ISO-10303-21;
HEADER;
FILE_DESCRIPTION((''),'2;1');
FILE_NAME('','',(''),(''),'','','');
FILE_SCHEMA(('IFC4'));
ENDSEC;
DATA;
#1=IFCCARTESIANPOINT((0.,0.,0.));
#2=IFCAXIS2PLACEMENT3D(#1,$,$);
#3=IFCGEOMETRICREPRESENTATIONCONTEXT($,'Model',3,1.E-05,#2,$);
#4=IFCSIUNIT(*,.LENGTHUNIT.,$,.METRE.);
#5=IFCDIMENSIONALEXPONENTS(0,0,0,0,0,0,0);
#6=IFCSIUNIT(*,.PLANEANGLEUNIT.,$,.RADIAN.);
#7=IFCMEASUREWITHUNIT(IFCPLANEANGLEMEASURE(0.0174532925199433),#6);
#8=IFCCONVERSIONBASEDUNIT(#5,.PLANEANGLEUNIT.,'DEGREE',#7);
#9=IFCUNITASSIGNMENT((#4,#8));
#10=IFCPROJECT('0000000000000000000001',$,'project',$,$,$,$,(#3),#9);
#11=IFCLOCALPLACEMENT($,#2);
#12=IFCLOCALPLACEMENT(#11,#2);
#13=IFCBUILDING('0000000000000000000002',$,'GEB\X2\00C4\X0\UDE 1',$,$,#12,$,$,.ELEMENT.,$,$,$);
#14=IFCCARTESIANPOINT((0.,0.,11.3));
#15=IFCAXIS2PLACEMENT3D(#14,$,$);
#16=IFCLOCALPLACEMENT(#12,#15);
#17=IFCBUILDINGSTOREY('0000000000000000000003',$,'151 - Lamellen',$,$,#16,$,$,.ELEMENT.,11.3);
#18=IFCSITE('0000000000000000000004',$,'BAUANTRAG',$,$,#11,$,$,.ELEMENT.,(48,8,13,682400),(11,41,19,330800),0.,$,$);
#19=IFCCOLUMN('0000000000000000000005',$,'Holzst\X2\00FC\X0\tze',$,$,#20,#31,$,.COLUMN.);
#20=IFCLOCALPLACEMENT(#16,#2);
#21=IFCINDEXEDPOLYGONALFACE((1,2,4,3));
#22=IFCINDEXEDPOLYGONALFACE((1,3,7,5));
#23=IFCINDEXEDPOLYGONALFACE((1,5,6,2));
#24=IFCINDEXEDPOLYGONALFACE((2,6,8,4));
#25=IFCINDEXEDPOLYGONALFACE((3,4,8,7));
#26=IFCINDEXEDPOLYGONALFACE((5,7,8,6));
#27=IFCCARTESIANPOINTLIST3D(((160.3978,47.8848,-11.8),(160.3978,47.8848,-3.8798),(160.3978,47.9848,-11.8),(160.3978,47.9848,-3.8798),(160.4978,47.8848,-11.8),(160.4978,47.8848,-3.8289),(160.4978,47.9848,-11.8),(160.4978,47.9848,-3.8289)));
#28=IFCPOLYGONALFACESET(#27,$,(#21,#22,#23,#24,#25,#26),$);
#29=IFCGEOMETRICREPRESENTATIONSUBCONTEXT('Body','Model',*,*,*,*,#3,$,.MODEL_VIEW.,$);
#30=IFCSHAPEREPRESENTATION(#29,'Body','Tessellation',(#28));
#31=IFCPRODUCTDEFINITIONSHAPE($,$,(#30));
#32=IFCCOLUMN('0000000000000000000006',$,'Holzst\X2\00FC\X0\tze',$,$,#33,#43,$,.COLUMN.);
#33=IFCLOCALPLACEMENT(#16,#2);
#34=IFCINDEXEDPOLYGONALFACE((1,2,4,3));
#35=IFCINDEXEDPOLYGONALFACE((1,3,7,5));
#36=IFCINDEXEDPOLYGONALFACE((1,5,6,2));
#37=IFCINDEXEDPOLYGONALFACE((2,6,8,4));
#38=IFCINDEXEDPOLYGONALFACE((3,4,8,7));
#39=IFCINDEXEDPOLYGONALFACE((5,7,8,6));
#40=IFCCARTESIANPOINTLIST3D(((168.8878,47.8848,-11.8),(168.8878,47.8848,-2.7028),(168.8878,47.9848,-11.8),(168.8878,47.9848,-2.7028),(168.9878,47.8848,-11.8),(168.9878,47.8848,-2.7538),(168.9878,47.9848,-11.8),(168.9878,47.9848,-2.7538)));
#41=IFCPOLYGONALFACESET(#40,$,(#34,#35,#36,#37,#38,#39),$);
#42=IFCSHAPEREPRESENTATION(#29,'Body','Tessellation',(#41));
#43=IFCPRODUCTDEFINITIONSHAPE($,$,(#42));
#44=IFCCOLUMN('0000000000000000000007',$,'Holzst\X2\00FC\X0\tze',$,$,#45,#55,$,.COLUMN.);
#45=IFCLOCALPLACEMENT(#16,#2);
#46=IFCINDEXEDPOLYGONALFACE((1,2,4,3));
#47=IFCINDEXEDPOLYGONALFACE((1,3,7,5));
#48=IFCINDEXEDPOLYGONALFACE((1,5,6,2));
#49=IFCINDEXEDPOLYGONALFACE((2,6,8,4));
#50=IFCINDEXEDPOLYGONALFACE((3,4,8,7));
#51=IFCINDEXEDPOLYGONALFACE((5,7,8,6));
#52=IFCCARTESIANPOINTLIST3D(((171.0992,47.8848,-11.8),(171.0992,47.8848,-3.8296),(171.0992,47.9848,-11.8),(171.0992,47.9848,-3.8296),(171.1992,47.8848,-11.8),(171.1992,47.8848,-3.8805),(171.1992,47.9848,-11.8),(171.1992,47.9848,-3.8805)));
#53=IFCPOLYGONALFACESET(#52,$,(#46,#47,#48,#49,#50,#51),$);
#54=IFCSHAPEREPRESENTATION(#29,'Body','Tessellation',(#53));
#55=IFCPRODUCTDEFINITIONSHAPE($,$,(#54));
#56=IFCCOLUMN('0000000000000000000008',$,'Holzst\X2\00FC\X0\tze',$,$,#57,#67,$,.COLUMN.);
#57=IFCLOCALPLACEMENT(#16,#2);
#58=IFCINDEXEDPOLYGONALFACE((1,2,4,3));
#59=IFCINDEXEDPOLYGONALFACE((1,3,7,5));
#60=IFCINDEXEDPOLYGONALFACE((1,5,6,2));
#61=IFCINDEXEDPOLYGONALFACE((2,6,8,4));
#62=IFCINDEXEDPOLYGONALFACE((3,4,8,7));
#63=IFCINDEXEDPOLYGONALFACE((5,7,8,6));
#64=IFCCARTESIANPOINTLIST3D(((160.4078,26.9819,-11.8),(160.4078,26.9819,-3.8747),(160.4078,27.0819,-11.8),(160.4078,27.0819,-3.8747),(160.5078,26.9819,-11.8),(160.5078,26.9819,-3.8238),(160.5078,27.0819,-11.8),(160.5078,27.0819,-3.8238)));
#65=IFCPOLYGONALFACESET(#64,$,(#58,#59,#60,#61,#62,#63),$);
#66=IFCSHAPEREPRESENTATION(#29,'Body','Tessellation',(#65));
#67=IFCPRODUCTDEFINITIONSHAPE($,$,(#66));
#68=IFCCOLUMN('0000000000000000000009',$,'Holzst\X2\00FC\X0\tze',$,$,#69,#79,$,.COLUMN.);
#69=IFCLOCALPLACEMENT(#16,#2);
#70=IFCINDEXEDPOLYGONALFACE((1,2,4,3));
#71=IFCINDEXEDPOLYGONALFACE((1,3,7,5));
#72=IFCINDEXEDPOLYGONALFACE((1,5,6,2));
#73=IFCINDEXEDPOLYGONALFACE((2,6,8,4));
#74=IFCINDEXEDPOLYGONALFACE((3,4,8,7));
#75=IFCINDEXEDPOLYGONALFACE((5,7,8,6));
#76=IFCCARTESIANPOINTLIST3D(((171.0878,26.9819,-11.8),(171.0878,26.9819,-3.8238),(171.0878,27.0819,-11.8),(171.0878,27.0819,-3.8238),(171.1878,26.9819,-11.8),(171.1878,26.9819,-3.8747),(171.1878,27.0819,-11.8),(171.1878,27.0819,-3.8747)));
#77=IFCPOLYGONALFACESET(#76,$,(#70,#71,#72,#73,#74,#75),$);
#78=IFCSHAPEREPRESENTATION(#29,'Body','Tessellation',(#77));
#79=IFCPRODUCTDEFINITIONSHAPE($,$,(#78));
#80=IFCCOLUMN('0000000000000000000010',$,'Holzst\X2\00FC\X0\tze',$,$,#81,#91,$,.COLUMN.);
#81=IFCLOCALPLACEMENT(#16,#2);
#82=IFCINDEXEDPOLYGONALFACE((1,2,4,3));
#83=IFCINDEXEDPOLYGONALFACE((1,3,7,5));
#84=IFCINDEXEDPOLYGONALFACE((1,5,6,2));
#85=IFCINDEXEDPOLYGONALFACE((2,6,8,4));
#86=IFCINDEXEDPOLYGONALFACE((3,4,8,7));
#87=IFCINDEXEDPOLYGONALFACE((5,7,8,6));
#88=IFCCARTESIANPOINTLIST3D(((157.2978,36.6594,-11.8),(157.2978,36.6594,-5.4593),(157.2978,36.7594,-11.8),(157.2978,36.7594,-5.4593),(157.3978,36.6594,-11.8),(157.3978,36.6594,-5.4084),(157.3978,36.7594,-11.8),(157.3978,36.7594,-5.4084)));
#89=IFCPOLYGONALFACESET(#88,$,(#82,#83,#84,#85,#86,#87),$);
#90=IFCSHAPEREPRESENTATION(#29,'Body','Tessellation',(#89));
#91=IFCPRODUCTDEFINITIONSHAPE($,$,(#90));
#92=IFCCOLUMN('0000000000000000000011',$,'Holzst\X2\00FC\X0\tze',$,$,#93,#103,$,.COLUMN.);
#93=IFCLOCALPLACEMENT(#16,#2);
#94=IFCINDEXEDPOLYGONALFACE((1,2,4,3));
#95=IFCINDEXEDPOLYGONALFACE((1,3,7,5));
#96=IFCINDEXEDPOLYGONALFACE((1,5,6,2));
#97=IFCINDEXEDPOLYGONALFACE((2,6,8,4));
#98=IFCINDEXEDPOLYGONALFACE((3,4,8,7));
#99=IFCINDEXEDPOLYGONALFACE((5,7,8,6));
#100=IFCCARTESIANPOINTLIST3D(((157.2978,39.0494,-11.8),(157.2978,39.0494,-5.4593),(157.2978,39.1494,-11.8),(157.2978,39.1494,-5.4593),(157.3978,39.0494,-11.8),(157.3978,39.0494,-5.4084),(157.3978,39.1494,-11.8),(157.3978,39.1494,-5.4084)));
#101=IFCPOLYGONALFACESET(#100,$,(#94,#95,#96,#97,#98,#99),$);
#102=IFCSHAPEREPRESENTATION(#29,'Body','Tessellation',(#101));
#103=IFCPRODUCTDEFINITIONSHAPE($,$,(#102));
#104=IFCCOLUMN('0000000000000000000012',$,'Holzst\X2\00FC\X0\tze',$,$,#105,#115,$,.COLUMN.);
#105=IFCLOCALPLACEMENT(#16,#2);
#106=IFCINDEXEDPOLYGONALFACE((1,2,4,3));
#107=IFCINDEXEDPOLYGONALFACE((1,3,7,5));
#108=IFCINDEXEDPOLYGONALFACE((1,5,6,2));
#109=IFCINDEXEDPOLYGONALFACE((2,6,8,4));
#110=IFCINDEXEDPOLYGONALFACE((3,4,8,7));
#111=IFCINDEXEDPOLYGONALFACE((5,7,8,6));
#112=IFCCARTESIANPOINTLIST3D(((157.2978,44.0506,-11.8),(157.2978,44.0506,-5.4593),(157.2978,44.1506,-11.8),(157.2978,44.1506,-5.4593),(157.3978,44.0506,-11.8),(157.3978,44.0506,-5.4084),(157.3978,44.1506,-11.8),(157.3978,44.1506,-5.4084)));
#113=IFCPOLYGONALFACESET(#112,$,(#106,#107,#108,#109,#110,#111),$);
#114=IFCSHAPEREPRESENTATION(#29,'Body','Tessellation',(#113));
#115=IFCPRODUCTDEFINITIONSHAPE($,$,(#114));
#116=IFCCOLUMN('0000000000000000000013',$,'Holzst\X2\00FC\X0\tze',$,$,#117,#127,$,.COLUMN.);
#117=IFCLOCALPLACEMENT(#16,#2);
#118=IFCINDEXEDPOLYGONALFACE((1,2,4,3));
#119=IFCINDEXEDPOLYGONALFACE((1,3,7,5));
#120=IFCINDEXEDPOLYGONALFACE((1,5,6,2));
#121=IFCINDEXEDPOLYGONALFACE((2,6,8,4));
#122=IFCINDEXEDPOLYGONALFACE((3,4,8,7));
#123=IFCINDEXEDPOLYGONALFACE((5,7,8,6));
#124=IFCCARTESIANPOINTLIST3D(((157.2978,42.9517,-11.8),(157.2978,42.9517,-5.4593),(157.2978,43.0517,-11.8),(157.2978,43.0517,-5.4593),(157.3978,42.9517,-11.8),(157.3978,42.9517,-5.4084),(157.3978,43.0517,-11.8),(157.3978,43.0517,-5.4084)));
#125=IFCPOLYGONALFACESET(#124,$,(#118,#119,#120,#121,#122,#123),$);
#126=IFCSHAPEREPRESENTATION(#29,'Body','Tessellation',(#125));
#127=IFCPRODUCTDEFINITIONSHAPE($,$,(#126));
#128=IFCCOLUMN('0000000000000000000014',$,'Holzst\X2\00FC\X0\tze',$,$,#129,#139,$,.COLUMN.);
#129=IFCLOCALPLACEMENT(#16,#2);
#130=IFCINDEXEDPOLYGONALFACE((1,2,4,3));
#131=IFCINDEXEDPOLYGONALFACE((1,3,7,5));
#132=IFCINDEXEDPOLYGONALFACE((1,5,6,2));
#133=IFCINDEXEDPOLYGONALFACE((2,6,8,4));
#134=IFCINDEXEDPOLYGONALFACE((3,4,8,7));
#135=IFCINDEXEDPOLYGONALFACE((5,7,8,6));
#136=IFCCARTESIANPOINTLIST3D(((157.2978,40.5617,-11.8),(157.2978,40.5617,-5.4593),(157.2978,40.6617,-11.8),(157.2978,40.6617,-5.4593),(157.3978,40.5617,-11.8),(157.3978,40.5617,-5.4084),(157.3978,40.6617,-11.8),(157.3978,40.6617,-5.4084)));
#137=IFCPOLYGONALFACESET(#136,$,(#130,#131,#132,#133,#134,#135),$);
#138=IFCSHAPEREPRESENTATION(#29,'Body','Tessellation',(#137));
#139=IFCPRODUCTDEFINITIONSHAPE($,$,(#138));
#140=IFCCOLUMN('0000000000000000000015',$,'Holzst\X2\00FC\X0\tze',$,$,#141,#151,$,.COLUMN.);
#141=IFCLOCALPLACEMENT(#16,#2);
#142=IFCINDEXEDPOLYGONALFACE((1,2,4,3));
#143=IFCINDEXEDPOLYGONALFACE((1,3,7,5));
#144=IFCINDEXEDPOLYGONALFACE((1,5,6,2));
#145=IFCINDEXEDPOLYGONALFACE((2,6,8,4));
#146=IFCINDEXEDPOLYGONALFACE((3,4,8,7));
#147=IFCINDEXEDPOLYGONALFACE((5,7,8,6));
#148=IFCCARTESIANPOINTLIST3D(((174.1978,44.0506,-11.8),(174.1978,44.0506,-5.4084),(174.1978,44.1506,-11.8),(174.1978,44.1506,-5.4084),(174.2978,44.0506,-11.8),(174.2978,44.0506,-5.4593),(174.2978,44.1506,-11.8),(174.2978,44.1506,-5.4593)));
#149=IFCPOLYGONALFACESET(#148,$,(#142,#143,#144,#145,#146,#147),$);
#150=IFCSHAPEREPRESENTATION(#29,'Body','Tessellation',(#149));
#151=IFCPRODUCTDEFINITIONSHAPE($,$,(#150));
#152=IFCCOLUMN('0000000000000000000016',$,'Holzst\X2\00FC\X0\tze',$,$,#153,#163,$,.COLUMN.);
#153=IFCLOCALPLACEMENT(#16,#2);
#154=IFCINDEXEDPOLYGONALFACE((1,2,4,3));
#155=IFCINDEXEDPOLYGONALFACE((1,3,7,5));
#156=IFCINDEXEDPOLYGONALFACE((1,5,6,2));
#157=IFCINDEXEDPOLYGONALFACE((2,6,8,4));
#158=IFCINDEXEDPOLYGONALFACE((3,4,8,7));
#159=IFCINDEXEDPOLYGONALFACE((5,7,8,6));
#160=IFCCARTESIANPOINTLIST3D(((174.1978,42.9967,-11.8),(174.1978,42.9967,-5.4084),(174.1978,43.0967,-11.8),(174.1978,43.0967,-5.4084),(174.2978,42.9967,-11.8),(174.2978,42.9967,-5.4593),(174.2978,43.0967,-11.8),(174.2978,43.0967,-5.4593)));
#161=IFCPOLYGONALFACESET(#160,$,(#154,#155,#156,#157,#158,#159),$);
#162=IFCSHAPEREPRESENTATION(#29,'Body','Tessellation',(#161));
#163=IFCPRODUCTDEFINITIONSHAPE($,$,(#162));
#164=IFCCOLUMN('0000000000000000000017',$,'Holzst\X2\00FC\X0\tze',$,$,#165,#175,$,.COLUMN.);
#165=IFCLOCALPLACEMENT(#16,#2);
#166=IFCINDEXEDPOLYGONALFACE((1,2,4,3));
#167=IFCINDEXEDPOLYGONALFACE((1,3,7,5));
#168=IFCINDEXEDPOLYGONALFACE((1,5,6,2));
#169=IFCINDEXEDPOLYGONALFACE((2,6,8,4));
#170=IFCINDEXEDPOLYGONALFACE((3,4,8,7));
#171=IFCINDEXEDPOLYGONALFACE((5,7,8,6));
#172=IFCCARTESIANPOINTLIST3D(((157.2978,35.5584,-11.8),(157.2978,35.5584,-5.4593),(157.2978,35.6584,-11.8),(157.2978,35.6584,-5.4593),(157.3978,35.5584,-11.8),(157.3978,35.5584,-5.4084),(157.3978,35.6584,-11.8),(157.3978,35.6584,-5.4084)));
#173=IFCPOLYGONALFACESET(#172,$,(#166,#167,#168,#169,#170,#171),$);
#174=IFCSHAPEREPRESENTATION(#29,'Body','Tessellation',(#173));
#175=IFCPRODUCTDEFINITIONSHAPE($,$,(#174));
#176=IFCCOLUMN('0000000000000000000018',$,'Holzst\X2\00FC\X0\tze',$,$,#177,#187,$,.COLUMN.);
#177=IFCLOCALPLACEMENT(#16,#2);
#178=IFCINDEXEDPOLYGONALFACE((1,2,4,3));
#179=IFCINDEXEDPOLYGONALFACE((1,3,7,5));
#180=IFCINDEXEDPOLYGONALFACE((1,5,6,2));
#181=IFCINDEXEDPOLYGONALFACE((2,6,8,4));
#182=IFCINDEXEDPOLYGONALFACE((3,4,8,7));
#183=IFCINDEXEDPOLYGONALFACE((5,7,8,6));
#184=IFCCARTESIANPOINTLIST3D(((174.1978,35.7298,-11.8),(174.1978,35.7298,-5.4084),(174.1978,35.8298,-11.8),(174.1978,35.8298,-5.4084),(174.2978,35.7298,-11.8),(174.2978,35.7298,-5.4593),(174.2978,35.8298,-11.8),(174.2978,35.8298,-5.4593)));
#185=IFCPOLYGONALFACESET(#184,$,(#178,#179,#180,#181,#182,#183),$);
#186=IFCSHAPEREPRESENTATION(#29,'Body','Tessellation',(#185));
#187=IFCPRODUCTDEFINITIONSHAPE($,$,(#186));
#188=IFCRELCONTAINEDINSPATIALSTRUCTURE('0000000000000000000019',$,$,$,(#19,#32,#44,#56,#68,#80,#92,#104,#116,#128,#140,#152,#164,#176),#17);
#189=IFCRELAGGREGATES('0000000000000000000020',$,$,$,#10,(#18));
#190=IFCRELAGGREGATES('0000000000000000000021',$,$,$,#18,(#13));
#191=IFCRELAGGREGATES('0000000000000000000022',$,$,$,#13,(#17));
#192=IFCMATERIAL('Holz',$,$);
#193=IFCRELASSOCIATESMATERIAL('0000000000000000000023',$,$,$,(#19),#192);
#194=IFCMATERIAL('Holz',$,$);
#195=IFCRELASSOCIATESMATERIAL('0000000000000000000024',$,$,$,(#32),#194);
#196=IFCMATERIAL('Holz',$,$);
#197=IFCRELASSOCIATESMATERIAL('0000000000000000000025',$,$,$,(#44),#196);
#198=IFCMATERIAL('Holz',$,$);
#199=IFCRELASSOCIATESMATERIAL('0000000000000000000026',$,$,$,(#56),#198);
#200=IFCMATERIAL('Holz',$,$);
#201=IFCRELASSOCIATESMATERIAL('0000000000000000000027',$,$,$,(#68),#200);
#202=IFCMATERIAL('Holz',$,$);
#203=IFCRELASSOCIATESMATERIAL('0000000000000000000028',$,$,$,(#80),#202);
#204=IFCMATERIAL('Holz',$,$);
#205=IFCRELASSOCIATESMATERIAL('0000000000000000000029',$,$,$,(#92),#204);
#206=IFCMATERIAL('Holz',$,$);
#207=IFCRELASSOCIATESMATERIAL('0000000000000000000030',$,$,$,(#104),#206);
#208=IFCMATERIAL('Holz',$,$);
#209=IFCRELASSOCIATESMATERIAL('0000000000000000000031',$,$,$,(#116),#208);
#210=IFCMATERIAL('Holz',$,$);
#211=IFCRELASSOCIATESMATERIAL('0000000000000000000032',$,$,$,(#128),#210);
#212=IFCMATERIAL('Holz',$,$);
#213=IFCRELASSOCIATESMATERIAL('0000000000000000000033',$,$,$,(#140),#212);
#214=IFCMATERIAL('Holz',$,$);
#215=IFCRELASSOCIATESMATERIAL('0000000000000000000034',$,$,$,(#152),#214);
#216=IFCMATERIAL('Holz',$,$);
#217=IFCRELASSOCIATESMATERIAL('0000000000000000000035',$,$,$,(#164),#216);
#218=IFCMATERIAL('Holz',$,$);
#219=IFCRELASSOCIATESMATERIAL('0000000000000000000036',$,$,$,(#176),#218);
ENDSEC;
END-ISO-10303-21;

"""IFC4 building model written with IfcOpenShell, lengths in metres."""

from ifc_helpers import new_model, entity, si_unit, converted_unit, frame, frame_2d, origin, origin_with_axes, place, context, subcontext, project, spatial, rectangle, extrude, clip, halfspace, material, element, save


model = new_model("IFC4")

# Units and contexts
model_context = context("Model", 3, precision=1e-05, world=origin())
body_context = subcontext(model_context, "Body", "Model", "MODEL_VIEW")
ifc_project = project(units=[si_unit("LENGTHUNIT", "METRE"), converted_unit("PLANEANGLEUNIT", "DEGREE", entity("IfcPlaneAngleMeasure", 0.0174532925199433), si_unit("PLANEANGLEUNIT", "RADIAN"), dimensions=[0, 0, 0, 0, 0, 0, 0])], contexts=[model_context])

# Site, building, storey
site_placement = place(None, origin())
site = spatial("IfcSite", under=ifc_project, at=site_placement, Name="BAUANTRAG", CompositionType="ELEMENT", RefLatitude=(48, 8, 13, 682400), RefLongitude=(11, 41, 19, 330800), RefElevation=0.0)
building_placement = place(site_placement, origin())
building = spatial("IfcBuilding", under=site, at=building_placement, Name="GEBÄUDE 1", CompositionType="ELEMENT")
storey_placement = place(building_placement, frame((0.0, 0.0, 11.3)))
storey = spatial("IfcBuildingStorey", under=building, at=storey_placement, Name="151 - Lamellen", CompositionType="ELEMENT", Elevation=11.3)

# Columns
ifc_material_1 = material(Name="Holz")
column_1_placement = place(storey_placement, frame((160.4978, 47.8848, -11.8)))
element("IfcColumn", 1, at=column_1_placement, inside=storey, material=ifc_material_1, Name="Holzstütze", PredefinedType="COLUMN", context=body_context, shape_type="Clipping", body=[
    clip(extrude(rectangle(XDim=0.1, YDim=0.1, at=frame_2d((-0.05, 0.05), x_axis=(0.0, 1.0))), origin_with_axes(), (0.0, 0.0, 1.0), 7.9711), halfspace(frame((-0.05, 0.05, 7.9457), z_axis=(0.45399, 0.0, -0.891007), x_axis=(0.0, 1.0, 0.0)), True)),
])
ifc_material_2 = material(Name="Holz")
column_2_placement = place(storey_placement, frame((168.9878, 47.8848, -11.8)))
element("IfcColumn", 2, at=column_2_placement, inside=storey, material=ifc_material_2, Name="Holzstütze", PredefinedType="COLUMN", context=body_context, shape_type="Clipping", body=[
    clip(extrude(rectangle(XDim=0.1, YDim=0.1, at=frame_2d((-0.05, 0.05), x_axis=(0.0, 1.0))), origin_with_axes(), (0.0, 0.0, 1.0), 9.0972), halfspace(frame((-0.05, 0.05, 9.0717), z_axis=(-0.45399, 0.0, -0.891007), x_axis=(0.0, 1.0, 0.0)), True)),
])
ifc_material_3 = material(Name="Holz")
column_3_placement = place(storey_placement, frame((171.1992, 47.8848, -11.8)))
element("IfcColumn", 3, at=column_3_placement, inside=storey, material=ifc_material_3, Name="Holzstütze", PredefinedType="COLUMN", context=body_context, shape_type="Clipping", body=[
    clip(extrude(rectangle(XDim=0.1, YDim=0.1, at=frame_2d((-0.05, 0.05), x_axis=(0.0, 1.0))), origin_with_axes(), (0.0, 0.0, 1.0), 7.9704), halfspace(frame((-0.05, 0.05, 7.9449), z_axis=(-0.45399, 0.0, -0.891007), x_axis=(0.0, 1.0, 0.0)), True)),
])
ifc_material_4 = material(Name="Holz")
column_4_placement = place(storey_placement, frame((160.5078, 26.9819, -11.8)))
element("IfcColumn", 4, at=column_4_placement, inside=storey, material=ifc_material_4, Name="Holzstütze", PredefinedType="COLUMN", context=body_context, shape_type="Clipping", body=[
    clip(extrude(rectangle(XDim=0.1, YDim=0.1, at=frame_2d((-0.05, 0.05), x_axis=(0.0, 1.0))), origin_with_axes(), (0.0, 0.0, 1.0), 7.9762), halfspace(frame((-0.05, 0.05, 7.9508), z_axis=(0.45399, 0.0, -0.891007), x_axis=(0.0, -1.0, 0.0)), True)),
])
ifc_material_5 = material(Name="Holz")
column_5_placement = place(storey_placement, frame((171.1878, 26.9819, -11.8)))
element("IfcColumn", 5, at=column_5_placement, inside=storey, material=ifc_material_5, Name="Holzstütze", PredefinedType="COLUMN", context=body_context, shape_type="Clipping", body=[
    clip(extrude(rectangle(XDim=0.1, YDim=0.1, at=frame_2d((-0.05, 0.05), x_axis=(0.0, 1.0))), origin_with_axes(), (0.0, 0.0, 1.0), 7.9762), halfspace(frame((-0.05, 0.05, 7.9508), z_axis=(-0.45399, 0.0, -0.891007), x_axis=(0.0, -1.0, 0.0)), True)),
])
ifc_material_6 = material(Name="Holz")
column_6_placement = place(storey_placement, frame((157.3978, 36.6594, -11.8)))
element("IfcColumn", 6, at=column_6_placement, inside=storey, material=ifc_material_6, Name="Holzstütze", PredefinedType="COLUMN", context=body_context, shape_type="Clipping", body=[
    clip(extrude(rectangle(XDim=0.1, YDim=0.1, at=frame_2d((-0.05, 0.05), x_axis=(0.0, 1.0))), origin_with_axes(), (0.0, 0.0, 1.0), 6.3916), halfspace(frame((-0.05, 0.05, 6.3661), z_axis=(0.45399, 0.0, -0.891007), x_axis=(-0.891007, 0.0, -0.45399)), True)),
])
ifc_material_7 = material(Name="Holz")
column_7_placement = place(storey_placement, frame((157.3978, 39.0494, -11.8)))
element("IfcColumn", 7, at=column_7_placement, inside=storey, material=ifc_material_7, Name="Holzstütze", PredefinedType="COLUMN", context=body_context, shape_type="Clipping", body=[
    clip(extrude(rectangle(XDim=0.1, YDim=0.1, at=frame_2d((-0.05, 0.05), x_axis=(0.0, 1.0))), origin_with_axes(), (0.0, 0.0, 1.0), 6.3916), halfspace(frame((-0.05, 0.05, 6.3661), z_axis=(0.45399, 0.0, -0.891007), x_axis=(-0.891007, 0.0, -0.45399)), True)),
])
ifc_material_8 = material(Name="Holz")
column_8_placement = place(storey_placement, frame((157.3978, 44.0506, -11.8)))
element("IfcColumn", 8, at=column_8_placement, inside=storey, material=ifc_material_8, Name="Holzstütze", PredefinedType="COLUMN", context=body_context, shape_type="Clipping", body=[
    clip(extrude(rectangle(XDim=0.1, YDim=0.1, at=frame_2d((-0.05, 0.05), x_axis=(0.0, 1.0))), origin_with_axes(), (0.0, 0.0, 1.0), 6.3916), halfspace(frame((-0.05, 0.05, 6.3661), z_axis=(0.45399, 0.0, -0.891007), x_axis=(-0.891007, 0.0, -0.45399)), True)),
])
ifc_material_9 = material(Name="Holz")
column_9_placement = place(storey_placement, frame((157.3978, 42.9517, -11.8)))
element("IfcColumn", 9, at=column_9_placement, inside=storey, material=ifc_material_9, Name="Holzstütze", PredefinedType="COLUMN", context=body_context, shape_type="Clipping", body=[
    clip(extrude(rectangle(XDim=0.1, YDim=0.1, at=frame_2d((-0.05, 0.05), x_axis=(0.0, 1.0))), origin_with_axes(), (0.0, 0.0, 1.0), 6.3916), halfspace(frame((-0.05, 0.05, 6.3661), z_axis=(0.45399, 0.0, -0.891007), x_axis=(-0.891007, 0.0, -0.45399)), True)),
])
ifc_material_10 = material(Name="Holz")
column_10_placement = place(storey_placement, frame((157.3978, 40.5617, -11.8)))
element("IfcColumn", 10, at=column_10_placement, inside=storey, material=ifc_material_10, Name="Holzstütze", PredefinedType="COLUMN", context=body_context, shape_type="Clipping", body=[
    clip(extrude(rectangle(XDim=0.1, YDim=0.1, at=frame_2d((-0.05, 0.05), x_axis=(0.0, 1.0))), origin_with_axes(), (0.0, 0.0, 1.0), 6.3916), halfspace(frame((-0.05, 0.05, 6.3661), z_axis=(0.45399, 0.0, -0.891007), x_axis=(-0.891007, 0.0, -0.45399)), True)),
])
ifc_material_11 = material(Name="Holz")
column_11_placement = place(storey_placement, frame((174.2978, 44.0506, -11.8)))
element("IfcColumn", 11, at=column_11_placement, inside=storey, material=ifc_material_11, Name="Holzstütze", PredefinedType="COLUMN", context=body_context, shape_type="Clipping", body=[
    clip(extrude(rectangle(XDim=0.1, YDim=0.1, at=frame_2d((-0.05, 0.05), x_axis=(0.0, 1.0))), origin_with_axes(), (0.0, 0.0, 1.0), 6.3916), halfspace(frame((-0.05, 0.05, 6.3661), z_axis=(-0.45399, 0.0, -0.891007), x_axis=(0.891007, 0.0, -0.45399)), True)),
])
ifc_material_12 = material(Name="Holz")
column_12_placement = place(storey_placement, frame((174.2978, 42.9967, -11.8)))
element("IfcColumn", 12, at=column_12_placement, inside=storey, material=ifc_material_12, Name="Holzstütze", PredefinedType="COLUMN", context=body_context, shape_type="Clipping", body=[
    clip(extrude(rectangle(XDim=0.1, YDim=0.1, at=frame_2d((-0.05, 0.05), x_axis=(0.0, 1.0))), origin_with_axes(), (0.0, 0.0, 1.0), 6.3916), halfspace(frame((-0.05, 0.05, 6.3661), z_axis=(-0.45399, 0.0, -0.891007), x_axis=(0.891007, 0.0, -0.45399)), True)),
])
ifc_material_13 = material(Name="Holz")
column_13_placement = place(storey_placement, frame((157.3978, 35.5584, -11.8)))
element("IfcColumn", 13, at=column_13_placement, inside=storey, material=ifc_material_13, Name="Holzstütze", PredefinedType="COLUMN", context=body_context, shape_type="Clipping", body=[
    clip(extrude(rectangle(XDim=0.1, YDim=0.1, at=frame_2d((-0.05, 0.05), x_axis=(0.0, 1.0))), origin_with_axes(), (0.0, 0.0, 1.0), 6.3916), halfspace(frame((-0.05, 0.05, 6.3661), z_axis=(0.45399, 0.0, -0.891007), x_axis=(-0.891007, 0.0, -0.45399)), True)),
])
ifc_material_14 = material(Name="Holz")
column_14_placement = place(storey_placement, frame((174.2978, 35.7298, -11.8)))
element("IfcColumn", 14, at=column_14_placement, inside=storey, material=ifc_material_14, Name="Holzstütze", PredefinedType="COLUMN", context=body_context, shape_type="Clipping", body=[
    clip(extrude(rectangle(XDim=0.1, YDim=0.1, at=frame_2d((-0.05, 0.05), x_axis=(0.0, 1.0))), origin_with_axes(), (0.0, 0.0, 1.0), 6.3916), halfspace(frame((-0.05, 0.05, 6.3661), z_axis=(-0.45399, 0.0, -0.891007), x_axis=(0.891007, 0.0, -0.45399)), True)),
])

save(model, "model.ifc")
